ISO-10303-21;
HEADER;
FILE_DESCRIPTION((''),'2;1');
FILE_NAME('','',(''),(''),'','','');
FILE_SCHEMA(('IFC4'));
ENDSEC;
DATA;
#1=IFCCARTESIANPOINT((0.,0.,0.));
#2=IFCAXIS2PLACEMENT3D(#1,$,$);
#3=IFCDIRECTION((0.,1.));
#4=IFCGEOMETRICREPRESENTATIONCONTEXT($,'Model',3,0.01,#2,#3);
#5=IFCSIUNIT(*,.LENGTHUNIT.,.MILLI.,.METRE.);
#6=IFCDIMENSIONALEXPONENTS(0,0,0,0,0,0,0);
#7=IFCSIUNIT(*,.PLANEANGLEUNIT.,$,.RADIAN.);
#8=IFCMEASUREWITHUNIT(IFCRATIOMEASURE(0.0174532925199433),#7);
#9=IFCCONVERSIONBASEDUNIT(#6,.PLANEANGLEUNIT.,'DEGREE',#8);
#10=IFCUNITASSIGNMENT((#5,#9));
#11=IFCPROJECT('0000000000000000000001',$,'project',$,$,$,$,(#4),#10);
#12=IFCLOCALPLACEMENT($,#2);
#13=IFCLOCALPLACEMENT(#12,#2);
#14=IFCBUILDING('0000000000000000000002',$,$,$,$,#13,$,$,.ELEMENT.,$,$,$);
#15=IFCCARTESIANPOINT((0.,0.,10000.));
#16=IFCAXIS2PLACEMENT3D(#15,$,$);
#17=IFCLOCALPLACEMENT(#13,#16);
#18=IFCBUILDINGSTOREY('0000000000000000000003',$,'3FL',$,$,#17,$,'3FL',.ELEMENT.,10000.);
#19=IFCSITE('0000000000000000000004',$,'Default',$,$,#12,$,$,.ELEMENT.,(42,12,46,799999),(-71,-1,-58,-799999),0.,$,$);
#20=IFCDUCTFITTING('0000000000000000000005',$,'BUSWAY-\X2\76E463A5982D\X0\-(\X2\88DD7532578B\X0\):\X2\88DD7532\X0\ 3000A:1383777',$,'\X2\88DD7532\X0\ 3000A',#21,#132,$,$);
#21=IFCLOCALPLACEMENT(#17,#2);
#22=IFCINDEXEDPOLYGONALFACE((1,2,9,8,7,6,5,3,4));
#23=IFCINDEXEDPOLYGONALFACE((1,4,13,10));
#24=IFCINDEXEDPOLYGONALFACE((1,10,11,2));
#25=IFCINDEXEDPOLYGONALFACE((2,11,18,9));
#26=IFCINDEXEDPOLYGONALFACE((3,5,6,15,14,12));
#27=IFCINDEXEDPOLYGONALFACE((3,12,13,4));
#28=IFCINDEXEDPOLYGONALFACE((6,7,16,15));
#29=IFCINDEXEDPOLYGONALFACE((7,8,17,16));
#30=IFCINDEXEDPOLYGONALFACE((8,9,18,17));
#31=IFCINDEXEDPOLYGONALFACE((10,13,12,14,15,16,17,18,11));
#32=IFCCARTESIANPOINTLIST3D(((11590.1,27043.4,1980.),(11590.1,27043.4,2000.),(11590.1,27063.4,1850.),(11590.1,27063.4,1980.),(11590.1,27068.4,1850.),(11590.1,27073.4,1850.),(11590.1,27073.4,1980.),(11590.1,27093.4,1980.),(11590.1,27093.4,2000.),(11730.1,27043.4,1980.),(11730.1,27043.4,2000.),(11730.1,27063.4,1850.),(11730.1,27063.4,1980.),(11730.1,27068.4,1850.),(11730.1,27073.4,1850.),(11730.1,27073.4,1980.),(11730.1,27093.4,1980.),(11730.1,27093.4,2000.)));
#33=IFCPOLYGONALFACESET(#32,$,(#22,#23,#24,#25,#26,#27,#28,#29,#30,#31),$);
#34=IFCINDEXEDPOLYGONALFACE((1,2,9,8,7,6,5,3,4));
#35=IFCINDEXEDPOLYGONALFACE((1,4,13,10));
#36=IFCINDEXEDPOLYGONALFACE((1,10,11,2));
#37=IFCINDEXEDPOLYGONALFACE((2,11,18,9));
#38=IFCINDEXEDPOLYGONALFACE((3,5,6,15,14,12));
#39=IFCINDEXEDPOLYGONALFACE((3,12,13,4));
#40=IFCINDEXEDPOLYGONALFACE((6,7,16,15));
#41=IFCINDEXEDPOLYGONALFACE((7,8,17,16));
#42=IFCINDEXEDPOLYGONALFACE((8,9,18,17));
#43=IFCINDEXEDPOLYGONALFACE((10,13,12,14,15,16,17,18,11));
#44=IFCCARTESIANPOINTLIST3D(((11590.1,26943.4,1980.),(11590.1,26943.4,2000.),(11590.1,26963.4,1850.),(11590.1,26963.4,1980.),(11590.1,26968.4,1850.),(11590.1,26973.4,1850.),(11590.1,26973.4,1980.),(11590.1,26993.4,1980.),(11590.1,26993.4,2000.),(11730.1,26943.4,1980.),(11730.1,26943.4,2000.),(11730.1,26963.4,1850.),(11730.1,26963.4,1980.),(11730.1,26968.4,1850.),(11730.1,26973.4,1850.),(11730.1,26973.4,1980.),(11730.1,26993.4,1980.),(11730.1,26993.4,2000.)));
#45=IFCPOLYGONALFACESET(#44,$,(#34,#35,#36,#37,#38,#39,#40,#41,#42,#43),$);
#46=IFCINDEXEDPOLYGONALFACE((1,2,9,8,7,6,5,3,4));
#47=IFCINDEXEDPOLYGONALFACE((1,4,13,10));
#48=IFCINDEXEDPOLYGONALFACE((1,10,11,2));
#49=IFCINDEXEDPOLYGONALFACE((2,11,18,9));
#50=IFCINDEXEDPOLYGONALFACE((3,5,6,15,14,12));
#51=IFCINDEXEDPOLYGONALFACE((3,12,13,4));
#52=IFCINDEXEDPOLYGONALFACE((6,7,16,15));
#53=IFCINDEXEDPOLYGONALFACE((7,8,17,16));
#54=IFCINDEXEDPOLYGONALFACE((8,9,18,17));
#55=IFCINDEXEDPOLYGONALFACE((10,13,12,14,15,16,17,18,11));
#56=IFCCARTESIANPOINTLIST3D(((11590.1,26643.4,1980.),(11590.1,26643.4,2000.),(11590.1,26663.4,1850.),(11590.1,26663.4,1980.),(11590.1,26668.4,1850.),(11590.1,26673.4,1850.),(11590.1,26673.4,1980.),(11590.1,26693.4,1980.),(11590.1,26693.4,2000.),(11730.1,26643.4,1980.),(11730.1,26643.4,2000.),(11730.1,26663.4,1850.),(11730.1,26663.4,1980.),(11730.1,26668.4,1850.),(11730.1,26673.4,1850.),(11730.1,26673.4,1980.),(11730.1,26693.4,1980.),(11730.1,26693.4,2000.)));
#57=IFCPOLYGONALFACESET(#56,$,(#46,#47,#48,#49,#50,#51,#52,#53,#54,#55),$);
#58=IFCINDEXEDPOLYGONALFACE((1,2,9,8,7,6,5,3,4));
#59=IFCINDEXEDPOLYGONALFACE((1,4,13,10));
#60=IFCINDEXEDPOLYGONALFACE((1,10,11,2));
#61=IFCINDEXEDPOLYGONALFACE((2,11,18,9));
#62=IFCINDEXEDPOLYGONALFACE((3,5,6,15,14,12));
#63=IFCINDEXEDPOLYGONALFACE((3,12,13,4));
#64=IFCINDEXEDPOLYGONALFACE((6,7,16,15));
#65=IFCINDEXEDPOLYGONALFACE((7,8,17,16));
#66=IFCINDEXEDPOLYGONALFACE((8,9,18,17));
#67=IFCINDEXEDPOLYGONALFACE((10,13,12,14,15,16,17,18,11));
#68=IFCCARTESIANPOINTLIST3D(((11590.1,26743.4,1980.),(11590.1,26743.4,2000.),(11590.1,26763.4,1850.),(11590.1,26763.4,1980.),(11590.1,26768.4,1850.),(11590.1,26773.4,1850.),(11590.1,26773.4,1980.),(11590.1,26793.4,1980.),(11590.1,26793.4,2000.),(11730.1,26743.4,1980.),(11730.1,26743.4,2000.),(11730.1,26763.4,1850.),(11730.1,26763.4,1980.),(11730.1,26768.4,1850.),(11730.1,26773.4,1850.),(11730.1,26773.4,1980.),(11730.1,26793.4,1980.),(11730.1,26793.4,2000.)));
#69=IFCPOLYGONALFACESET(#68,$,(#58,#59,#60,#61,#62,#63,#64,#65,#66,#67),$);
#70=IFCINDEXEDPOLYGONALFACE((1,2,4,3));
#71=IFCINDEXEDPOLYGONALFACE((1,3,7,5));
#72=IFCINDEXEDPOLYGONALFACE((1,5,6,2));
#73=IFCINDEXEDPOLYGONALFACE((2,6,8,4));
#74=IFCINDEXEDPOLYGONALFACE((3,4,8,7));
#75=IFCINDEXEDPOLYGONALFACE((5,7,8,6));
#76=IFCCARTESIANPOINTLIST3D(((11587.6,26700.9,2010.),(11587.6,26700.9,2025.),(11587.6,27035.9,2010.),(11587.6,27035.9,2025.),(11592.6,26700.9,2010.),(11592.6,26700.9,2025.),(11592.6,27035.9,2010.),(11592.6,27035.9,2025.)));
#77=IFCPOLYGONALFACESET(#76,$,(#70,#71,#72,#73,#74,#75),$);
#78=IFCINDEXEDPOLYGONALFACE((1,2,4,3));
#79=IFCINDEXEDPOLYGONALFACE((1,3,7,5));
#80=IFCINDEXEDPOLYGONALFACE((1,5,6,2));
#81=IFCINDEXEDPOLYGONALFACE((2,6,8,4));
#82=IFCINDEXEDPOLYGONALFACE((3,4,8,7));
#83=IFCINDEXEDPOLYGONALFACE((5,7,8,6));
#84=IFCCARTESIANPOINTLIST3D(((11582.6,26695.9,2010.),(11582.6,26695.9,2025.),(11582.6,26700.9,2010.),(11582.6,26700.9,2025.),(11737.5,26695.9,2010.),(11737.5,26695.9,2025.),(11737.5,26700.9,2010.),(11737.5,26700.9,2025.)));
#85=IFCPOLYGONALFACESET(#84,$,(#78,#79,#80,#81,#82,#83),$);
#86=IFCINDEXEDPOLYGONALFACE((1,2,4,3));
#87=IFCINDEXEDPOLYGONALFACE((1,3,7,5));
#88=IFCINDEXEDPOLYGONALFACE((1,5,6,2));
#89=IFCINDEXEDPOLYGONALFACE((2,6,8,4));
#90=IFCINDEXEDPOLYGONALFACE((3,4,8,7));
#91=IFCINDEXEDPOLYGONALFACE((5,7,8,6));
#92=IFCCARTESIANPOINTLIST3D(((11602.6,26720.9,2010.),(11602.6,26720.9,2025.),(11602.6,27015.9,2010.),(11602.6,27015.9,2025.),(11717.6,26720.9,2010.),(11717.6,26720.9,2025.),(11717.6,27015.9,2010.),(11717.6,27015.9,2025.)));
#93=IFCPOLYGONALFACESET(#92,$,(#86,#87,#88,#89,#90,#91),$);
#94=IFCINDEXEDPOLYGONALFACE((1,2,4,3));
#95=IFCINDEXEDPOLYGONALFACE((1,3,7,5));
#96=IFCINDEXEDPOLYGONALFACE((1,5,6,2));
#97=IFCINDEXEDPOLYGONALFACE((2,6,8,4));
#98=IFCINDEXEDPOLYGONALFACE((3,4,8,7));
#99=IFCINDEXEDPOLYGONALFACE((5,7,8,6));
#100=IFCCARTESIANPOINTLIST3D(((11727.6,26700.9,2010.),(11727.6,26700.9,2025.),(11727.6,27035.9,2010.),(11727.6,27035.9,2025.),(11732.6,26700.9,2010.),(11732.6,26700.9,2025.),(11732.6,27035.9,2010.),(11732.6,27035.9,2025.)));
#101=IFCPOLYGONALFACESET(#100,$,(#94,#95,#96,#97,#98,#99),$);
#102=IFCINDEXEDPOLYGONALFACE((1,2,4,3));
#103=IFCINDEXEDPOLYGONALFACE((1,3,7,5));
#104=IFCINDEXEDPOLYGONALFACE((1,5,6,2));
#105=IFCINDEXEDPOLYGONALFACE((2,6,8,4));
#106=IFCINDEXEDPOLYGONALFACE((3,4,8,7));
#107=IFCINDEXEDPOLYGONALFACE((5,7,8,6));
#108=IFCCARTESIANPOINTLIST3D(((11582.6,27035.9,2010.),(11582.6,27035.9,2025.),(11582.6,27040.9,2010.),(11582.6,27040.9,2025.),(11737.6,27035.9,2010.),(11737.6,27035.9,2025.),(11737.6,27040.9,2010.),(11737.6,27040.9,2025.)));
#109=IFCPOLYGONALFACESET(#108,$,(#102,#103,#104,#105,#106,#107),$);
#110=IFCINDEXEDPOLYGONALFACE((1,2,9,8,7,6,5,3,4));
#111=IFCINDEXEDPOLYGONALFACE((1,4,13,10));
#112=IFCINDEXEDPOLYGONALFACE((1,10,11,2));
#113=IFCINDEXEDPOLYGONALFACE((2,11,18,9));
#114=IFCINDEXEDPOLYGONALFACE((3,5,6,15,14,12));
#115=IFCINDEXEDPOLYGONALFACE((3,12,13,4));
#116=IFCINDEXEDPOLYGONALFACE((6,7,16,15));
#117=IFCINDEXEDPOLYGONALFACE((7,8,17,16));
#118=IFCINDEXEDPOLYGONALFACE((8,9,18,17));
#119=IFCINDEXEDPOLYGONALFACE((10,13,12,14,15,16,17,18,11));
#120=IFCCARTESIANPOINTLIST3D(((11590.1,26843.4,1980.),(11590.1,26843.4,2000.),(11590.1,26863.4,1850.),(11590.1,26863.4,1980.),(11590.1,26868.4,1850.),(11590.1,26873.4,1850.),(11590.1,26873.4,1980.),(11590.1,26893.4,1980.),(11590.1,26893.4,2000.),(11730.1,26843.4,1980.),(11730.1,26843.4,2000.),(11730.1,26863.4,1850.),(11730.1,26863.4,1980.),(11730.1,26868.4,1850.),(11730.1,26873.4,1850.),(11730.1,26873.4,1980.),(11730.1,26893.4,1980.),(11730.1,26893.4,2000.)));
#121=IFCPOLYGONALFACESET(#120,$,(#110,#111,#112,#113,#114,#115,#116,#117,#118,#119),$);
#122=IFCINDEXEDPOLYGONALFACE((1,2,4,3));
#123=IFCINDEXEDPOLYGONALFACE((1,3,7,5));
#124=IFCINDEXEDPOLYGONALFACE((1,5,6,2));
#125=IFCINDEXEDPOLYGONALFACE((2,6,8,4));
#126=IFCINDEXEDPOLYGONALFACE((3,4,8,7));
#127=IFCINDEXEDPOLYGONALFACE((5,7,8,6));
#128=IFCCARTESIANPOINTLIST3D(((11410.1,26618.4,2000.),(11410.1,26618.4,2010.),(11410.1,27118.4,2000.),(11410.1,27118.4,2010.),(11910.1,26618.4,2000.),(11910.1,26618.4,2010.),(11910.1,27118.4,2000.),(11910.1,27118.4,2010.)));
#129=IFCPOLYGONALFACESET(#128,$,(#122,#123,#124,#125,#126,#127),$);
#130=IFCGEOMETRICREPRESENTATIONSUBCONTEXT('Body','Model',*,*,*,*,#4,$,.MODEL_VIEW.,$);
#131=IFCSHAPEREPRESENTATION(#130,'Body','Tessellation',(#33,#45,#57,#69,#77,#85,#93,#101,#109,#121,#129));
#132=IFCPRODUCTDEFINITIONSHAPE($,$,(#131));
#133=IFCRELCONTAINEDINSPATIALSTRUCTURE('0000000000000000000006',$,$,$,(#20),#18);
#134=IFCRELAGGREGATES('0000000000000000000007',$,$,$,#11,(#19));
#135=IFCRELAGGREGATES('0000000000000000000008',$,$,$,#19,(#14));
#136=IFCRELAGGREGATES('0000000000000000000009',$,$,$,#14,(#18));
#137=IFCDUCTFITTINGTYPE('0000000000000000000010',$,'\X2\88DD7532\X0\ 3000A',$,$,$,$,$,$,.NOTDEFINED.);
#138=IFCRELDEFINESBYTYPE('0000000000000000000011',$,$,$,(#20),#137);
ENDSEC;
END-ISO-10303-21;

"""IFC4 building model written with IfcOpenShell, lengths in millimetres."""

from ifc_helpers import new_model, entity, si_unit, converted_unit, direction, frame, frame_2d, origin, origin_2d_with_axis, place, context, subcontext, project, spatial, polyline, rectangle, outline, extrude, source, transform, mapped, type_object, type_shapes, element, save


model = new_model("IFC4")

# Units and contexts
model_context = context("Model", 3, precision=0.01, world=origin(), true_north=direction((0.0, 1.0)))
body_context = subcontext(model_context, "Body", "Model", "MODEL_VIEW")
ifc_project = project(units=[si_unit("LENGTHUNIT", "METRE", prefix="MILLI"), converted_unit("PLANEANGLEUNIT", "DEGREE", entity("IfcRatioMeasure", 0.0174532925199433), si_unit("PLANEANGLEUNIT", "RADIAN"), dimensions=[0, 0, 0, 0, 0, 0, 0])], contexts=[model_context])

# Site, building, storey
site_placement = place(None, origin())
site = spatial("IfcSite", under=ifc_project, at=site_placement, Name="Default", CompositionType="ELEMENT", RefLatitude=(42, 12, 46, 799999), RefLongitude=(-71, -1, -58, -799999), RefElevation=0.0)
building_placement = place(site_placement, origin())
building = spatial("IfcBuilding", under=site, at=building_placement, CompositionType="ELEMENT")
storey_placement = place(building_placement, frame((0.0, 0.0, 10000.0)))
storey = spatial("IfcBuildingStorey", under=building, at=storey_placement, Name="3FL", LongName="3FL", CompositionType="ELEMENT", Elevation=10000.0)

# Duct fitting
duct_fitting_type_1 = type_object("IfcDuctFittingType", Name="裝甲 3000A", PredefinedType="NOTDEFINED")
shared_shape_1 = source(origin(), body_context, "Body", "SweptSolid", [
    extrude(outline(polyline([(-25.0, -58.9), (25.0, -58.9), (25.0, -38.9), (5.0, -38.9), (5.0, 91.1), (0.0, 91.1), (-5.0, 91.1), (-5.0, -38.9), (-25.0, -38.9), (-25.0, -58.9)])), frame((-200.0, -70.0, -58.9), z_axis=(0.0, 1.0, 0.0), x_axis=(1.0, 0.0, 0.0)), (0.0, 0.0, 1.0), 140.0),
    extrude(outline(polyline([(-25.0, -58.9), (25.0, -58.9), (25.0, -38.9), (5.0, -38.9), (5.0, 91.1), (0.0, 91.1), (-5.0, 91.1), (-5.0, -38.9), (-25.0, -38.9), (-25.0, -58.9)])), frame((-100.0, -70.0, -58.9), z_axis=(0.0, 1.0, 0.0), x_axis=(1.0, 0.0, 0.0)), (0.0, 0.0, 1.0), 140.0),
    extrude(outline(polyline([(-58.9, -25.0), (-38.9, -25.0), (-38.9, -5.0), (91.1, -5.0), (91.1, 0.0), (91.1, 5.0), (-38.9, 5.0), (-38.9, 25.0), (-58.9, 25.0), (-58.9, -25.0)])), frame((200.0, -70.0, -58.9), z_axis=(0.0, 1.0, 0.0), x_axis=(0.0, 0.0, -1.0)), (0.0, 0.0, 1.0), 140.0),
    extrude(outline(polyline([(-58.9, -25.0), (-38.9, -25.0), (-38.9, -5.0), (91.1, -5.0), (91.1, 0.0), (91.1, 5.0), (-38.9, 5.0), (-38.9, 25.0), (-58.9, 25.0), (-58.9, -25.0)])), frame((100.0, -70.0, -58.9), z_axis=(0.0, 1.0, 0.0), x_axis=(0.0, 0.0, -1.0)), (0.0, 0.0, 1.0), 140.0),
    extrude(rectangle(XDim=335.0, YDim=5.0, at=origin_2d_with_axis()), frame((0.0, -70.0, 10.0), z_axis=(0.0, 0.0, 1.0), x_axis=(-1.0, 0.0, 0.0)), (0.0, 0.0, 1.0), 15.0),
    extrude(rectangle(XDim=5.0, YDim=154.9, at=frame_2d((0.0, 0.0), x_axis=(1.0, 0.0))), frame((170.0, -0.1, 10.0), z_axis=(0.0, 0.0, 1.0), x_axis=(-1.0, 0.0, 0.0)), (0.0, 0.0, 1.0), 15.0),
    extrude(rectangle(XDim=295.0, YDim=115.0, at=origin_2d_with_axis()), frame((0.0, 0.0, 10.0), z_axis=(0.0, 0.0, 1.0), x_axis=(-1.0, 0.0, 0.0)), (0.0, 0.0, 1.0), 15.0),
    extrude(rectangle(XDim=335.0, YDim=5.0, at=origin_2d_with_axis()), frame((0.0, 70.0, 10.0), z_axis=(0.0, 0.0, 1.0), x_axis=(-1.0, 0.0, 0.0)), (0.0, 0.0, 1.0), 15.0),
    extrude(rectangle(XDim=5.0, YDim=155.0, at=origin_2d_with_axis()), frame((-170.0, 0.0, 10.0), z_axis=(0.0, 0.0, 1.0), x_axis=(-1.0, 0.0, 0.0)), (0.0, 0.0, 1.0), 15.0),
    extrude(outline(polyline([(-58.9, -25.0), (-38.9, -25.0), (-38.9, -5.0), (91.1, -5.0), (91.1, 0.0), (91.1, 5.0), (-38.9, 5.0), (-38.9, 25.0), (-58.9, 25.0), (-58.9, -25.0)])), frame((0.0, -70.0, -58.9), z_axis=(0.0, 1.0, 0.0), x_axis=(0.0, 0.0, -1.0)), (0.0, 0.0, 1.0), 140.0),
    extrude(rectangle(XDim=500.0, YDim=500.0, at=origin_2d_with_axis()), frame((0.0, 0.0, 0.0), z_axis=(0.0, 0.0, 1.0), x_axis=(0.0, 1.0, 0.0)), (0.0, 0.0, 1.0), 10.0),
])
type_shapes(duct_fitting_type_1, [shared_shape_1])
for number, where, z_axis, x_axis, name in (
    (1, (11660.1, 26868.4, 2000.0), (0.0, 0.0, 1.0), (0.0, -1.0, 0.0), "BUSWAY-盤接頭-(裝甲型):裝甲 3000A:1383777"),
):
    element("IfcDuctFitting", number, at=place(storey_placement, frame(where, z_axis=z_axis, x_axis=x_axis)), inside=storey, type_object=duct_fitting_type_1, Name=name, ObjectType="裝甲 3000A", context=body_context, shape_type="MappedRepresentation", body=[
        mapped(shared_shape_1, transform((0.0, 0.0, 0.0), scale=1.0)),
    ])

save(model, "model.ifc")
